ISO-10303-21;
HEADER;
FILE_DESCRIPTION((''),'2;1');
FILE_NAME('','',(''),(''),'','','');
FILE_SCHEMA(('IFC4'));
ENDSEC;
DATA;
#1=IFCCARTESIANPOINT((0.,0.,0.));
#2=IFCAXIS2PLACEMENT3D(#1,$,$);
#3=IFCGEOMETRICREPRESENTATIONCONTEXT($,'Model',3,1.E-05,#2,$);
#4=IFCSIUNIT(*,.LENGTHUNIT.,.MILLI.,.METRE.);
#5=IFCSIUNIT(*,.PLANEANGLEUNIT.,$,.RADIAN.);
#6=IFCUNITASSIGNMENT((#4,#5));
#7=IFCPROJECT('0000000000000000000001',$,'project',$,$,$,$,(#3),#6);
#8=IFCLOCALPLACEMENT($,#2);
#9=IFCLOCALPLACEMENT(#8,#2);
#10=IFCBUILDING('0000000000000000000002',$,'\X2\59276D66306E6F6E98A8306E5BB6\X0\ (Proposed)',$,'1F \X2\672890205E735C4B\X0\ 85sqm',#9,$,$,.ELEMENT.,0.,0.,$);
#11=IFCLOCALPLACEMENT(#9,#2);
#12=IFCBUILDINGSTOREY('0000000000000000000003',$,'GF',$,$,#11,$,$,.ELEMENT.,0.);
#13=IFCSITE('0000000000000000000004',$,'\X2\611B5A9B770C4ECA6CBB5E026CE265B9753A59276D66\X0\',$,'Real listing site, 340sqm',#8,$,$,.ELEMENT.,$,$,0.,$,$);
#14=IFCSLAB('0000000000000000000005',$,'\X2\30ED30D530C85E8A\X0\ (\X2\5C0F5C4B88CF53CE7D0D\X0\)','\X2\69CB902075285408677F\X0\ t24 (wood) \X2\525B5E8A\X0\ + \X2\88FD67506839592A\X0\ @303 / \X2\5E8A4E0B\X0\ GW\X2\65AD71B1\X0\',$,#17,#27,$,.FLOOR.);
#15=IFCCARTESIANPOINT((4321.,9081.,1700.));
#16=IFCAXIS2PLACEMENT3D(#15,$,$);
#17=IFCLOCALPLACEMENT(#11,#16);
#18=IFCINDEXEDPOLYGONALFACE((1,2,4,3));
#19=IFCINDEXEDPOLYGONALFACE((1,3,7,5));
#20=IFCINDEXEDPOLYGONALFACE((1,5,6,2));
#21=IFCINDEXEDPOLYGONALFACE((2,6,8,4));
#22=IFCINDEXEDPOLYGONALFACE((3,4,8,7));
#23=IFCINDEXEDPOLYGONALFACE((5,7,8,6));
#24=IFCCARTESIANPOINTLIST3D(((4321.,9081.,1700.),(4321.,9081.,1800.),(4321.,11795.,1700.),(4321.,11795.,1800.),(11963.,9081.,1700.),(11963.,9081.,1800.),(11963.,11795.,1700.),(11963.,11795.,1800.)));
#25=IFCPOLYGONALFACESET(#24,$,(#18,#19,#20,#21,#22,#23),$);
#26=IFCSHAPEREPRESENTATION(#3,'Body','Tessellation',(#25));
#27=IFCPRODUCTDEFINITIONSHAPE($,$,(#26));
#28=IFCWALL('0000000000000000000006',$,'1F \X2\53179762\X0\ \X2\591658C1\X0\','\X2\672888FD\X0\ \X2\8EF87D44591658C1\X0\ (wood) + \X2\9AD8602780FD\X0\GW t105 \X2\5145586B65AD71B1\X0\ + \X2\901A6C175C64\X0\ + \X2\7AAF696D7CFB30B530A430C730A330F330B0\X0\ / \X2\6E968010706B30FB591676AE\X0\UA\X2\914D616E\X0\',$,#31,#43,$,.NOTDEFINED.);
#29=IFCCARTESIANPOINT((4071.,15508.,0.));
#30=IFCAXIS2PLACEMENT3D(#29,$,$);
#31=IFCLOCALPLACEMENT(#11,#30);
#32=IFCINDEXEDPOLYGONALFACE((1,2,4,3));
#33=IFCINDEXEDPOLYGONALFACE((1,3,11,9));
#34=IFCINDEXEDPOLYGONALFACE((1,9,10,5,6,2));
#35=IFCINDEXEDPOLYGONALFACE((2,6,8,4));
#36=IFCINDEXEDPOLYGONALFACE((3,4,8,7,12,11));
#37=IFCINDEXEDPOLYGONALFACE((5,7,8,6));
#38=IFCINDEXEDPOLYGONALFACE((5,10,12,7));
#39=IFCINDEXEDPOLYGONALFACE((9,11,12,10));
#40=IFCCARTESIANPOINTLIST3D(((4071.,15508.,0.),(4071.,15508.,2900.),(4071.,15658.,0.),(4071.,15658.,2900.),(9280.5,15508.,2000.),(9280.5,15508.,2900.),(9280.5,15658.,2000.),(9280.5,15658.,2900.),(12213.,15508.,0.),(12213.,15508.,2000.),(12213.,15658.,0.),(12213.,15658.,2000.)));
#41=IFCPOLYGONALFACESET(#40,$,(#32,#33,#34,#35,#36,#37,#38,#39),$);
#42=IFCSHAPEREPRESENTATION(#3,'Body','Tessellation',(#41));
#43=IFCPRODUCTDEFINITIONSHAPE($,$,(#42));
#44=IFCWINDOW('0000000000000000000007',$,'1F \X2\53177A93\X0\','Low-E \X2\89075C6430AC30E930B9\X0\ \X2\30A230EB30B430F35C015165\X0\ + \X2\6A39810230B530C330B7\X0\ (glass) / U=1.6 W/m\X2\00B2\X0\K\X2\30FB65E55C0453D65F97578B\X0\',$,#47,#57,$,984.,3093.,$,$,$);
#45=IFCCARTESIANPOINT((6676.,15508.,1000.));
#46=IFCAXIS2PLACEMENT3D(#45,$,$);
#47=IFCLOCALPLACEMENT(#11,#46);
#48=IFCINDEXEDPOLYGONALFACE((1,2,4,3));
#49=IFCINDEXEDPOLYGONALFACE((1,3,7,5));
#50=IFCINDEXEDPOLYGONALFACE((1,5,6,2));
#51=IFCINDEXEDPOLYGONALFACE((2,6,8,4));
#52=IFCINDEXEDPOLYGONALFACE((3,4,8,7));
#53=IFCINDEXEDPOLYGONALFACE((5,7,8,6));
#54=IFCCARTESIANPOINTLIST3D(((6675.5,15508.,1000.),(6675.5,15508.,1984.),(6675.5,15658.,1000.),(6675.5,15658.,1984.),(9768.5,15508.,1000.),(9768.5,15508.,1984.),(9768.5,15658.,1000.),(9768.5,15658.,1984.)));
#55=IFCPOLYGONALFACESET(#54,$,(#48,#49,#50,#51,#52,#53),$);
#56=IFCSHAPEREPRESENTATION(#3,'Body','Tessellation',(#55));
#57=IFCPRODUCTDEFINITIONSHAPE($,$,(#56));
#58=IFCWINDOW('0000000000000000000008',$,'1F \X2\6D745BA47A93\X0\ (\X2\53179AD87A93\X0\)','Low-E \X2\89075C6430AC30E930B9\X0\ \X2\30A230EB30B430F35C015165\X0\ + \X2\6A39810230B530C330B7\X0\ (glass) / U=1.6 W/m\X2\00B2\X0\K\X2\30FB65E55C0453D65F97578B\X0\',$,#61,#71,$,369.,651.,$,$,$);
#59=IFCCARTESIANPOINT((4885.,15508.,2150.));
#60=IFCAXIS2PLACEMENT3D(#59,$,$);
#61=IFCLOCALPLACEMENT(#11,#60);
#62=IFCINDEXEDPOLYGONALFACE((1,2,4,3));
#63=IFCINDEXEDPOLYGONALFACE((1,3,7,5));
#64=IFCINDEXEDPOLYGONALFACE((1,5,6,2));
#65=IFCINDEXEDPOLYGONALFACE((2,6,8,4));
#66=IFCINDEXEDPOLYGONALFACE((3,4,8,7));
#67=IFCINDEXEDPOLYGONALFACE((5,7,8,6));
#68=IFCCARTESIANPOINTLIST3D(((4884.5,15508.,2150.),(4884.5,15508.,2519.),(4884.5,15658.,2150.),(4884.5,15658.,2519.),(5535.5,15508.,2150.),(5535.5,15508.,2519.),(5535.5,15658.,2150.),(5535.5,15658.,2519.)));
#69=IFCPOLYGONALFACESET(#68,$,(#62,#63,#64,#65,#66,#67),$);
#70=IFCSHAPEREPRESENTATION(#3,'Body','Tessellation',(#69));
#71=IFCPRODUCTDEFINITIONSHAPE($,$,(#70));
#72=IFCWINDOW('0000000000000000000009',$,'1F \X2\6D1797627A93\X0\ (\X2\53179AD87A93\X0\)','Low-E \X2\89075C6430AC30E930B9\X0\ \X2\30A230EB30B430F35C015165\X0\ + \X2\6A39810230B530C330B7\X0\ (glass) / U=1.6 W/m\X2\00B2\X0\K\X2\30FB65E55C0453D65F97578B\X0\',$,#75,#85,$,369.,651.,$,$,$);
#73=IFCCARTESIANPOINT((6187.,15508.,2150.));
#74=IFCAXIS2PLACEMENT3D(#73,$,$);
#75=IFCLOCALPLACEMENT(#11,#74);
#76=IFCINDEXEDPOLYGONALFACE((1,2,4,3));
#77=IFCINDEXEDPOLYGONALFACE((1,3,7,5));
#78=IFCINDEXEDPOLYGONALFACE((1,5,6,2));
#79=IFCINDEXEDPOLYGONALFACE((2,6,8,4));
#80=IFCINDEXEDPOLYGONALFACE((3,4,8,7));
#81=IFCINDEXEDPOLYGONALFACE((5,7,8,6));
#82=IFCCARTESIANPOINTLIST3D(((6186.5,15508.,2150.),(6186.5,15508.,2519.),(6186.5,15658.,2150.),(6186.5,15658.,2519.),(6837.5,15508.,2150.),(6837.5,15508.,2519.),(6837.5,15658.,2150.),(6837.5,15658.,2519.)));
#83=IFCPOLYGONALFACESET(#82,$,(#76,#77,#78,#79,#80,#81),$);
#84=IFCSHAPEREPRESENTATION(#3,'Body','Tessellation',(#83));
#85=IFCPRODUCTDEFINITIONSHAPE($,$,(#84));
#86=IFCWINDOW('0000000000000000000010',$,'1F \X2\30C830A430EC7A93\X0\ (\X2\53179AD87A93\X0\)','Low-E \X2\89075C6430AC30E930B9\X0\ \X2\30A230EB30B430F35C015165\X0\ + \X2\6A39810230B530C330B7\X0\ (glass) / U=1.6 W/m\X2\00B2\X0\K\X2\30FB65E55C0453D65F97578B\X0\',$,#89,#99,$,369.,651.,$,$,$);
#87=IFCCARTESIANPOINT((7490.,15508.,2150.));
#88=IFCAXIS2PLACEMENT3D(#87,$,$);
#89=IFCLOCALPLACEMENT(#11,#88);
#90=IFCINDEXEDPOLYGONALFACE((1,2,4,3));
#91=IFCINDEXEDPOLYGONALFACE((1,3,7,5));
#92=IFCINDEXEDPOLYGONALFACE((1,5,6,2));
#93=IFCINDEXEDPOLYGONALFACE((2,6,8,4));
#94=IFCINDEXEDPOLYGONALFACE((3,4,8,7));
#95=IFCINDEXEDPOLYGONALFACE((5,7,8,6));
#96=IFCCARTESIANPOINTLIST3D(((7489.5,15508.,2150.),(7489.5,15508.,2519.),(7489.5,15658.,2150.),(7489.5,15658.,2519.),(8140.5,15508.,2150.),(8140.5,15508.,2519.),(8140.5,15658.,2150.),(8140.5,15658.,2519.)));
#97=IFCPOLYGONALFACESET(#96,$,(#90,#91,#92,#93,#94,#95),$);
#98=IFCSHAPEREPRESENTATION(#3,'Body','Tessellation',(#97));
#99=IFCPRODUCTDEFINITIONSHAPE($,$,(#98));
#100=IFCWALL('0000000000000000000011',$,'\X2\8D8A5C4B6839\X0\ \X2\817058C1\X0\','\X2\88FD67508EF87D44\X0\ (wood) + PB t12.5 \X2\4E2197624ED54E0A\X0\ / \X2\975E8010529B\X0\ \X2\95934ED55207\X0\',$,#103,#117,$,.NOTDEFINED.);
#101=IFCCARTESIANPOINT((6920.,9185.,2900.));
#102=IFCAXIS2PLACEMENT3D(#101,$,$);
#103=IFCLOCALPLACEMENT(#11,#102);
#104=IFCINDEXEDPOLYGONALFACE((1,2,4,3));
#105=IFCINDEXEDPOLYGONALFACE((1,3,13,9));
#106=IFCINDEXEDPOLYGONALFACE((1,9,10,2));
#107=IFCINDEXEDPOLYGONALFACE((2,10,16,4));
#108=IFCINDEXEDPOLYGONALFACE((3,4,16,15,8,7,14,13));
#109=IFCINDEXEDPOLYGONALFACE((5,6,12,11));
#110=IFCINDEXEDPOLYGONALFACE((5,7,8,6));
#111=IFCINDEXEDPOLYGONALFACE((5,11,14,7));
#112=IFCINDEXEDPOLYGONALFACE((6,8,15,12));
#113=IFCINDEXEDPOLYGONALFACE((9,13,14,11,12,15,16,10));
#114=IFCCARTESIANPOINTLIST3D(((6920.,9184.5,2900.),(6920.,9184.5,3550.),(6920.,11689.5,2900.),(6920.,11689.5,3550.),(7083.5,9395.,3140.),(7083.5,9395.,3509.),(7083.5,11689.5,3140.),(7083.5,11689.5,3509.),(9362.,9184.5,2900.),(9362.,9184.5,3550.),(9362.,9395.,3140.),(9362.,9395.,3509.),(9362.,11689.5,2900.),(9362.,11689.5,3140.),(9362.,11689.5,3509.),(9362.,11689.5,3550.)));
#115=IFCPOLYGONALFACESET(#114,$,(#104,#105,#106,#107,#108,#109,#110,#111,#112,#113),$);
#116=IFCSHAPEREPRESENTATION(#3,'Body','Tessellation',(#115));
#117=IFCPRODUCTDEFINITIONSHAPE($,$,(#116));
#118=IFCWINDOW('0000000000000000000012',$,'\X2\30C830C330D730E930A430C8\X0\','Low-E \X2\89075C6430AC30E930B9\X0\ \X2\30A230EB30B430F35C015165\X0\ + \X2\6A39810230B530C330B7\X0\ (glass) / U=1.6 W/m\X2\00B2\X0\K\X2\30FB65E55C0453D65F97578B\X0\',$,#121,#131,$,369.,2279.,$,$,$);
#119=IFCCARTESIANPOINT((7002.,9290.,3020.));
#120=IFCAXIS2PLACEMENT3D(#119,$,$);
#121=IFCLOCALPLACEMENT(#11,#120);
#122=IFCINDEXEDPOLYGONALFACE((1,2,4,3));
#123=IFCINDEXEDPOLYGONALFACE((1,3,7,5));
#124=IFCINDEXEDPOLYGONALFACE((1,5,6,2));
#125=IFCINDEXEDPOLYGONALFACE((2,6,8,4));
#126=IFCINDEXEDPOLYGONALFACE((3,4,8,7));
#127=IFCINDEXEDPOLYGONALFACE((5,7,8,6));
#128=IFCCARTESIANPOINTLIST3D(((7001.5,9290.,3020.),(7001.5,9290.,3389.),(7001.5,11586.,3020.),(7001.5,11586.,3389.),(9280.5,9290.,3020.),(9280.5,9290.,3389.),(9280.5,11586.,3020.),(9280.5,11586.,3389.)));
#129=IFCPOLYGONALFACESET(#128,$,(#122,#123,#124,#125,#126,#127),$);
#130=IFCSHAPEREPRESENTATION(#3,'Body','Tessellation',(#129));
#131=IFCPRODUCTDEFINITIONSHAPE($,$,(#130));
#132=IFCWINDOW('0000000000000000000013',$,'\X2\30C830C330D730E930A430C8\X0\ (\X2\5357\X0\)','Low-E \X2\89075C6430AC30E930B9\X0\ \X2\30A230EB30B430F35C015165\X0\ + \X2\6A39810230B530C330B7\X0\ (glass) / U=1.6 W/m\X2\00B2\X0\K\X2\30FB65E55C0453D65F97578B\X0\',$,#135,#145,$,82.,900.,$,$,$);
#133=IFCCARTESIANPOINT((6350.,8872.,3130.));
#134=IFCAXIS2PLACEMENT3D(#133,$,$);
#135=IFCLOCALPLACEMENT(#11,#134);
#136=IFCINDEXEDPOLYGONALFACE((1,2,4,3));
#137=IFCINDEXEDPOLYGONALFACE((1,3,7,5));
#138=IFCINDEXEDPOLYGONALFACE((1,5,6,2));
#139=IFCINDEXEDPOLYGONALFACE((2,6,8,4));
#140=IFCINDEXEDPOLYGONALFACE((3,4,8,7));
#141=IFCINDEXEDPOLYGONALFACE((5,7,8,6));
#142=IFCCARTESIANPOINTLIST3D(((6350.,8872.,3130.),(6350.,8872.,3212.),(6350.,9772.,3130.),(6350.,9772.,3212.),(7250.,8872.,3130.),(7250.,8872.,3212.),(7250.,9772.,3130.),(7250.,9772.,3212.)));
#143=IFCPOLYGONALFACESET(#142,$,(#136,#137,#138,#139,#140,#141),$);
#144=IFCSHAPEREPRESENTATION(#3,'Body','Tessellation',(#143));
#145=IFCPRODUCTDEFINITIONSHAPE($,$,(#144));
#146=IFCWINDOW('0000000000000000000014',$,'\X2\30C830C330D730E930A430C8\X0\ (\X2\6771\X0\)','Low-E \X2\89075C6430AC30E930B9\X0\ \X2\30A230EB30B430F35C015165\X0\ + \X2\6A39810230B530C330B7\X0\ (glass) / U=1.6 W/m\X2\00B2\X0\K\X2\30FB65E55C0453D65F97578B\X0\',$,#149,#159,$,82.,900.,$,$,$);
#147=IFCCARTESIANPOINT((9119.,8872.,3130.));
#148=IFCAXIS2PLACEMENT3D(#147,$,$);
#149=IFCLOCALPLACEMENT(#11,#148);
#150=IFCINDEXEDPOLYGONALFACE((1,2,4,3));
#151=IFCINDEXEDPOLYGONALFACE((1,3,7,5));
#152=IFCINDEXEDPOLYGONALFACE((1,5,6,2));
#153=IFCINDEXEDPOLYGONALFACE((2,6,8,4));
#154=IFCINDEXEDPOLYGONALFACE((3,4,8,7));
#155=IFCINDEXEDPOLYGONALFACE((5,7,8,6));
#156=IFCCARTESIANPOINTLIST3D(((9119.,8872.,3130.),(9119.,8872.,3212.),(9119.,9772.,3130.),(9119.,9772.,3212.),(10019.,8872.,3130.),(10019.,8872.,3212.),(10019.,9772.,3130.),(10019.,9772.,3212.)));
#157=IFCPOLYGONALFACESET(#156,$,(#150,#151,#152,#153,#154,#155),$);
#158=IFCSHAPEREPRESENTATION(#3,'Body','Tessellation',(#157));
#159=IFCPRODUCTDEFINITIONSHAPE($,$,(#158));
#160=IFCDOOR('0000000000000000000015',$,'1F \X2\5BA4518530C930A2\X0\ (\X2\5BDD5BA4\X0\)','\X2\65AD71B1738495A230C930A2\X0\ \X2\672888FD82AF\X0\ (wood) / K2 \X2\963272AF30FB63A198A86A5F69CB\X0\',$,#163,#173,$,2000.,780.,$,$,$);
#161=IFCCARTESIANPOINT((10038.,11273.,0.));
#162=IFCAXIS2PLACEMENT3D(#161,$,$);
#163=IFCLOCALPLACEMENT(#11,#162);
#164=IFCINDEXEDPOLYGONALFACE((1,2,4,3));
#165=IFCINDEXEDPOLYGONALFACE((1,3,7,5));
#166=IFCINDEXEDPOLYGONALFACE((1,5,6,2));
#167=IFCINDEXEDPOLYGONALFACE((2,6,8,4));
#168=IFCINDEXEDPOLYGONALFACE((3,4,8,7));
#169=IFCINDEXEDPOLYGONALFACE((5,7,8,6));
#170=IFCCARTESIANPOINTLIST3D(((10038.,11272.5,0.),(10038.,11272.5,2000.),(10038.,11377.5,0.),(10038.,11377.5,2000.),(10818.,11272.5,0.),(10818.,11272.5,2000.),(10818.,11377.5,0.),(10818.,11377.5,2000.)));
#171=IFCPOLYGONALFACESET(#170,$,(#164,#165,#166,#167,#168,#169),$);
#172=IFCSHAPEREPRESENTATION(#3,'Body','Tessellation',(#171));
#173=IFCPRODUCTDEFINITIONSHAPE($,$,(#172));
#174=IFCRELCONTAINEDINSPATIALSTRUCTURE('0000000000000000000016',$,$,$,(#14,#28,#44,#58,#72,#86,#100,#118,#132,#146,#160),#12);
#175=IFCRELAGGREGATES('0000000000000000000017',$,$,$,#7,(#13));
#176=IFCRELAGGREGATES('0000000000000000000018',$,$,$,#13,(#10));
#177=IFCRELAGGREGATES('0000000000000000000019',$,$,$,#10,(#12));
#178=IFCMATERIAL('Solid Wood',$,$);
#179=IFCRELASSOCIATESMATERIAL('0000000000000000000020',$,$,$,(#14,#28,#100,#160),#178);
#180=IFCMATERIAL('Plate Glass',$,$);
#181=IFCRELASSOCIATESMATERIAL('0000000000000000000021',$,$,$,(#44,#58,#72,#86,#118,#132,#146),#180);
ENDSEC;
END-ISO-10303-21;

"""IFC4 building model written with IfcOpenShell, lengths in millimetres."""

from ifc_helpers import new_model, si_unit, frame, frame_2d, origin, place, context, project, spatial, rectangle, extrude, material, element, fill, save


model = new_model("IFC4")

# Units and contexts
model_context = context("Model", 3, precision=1e-05, world=origin())
ifc_project = project(units=[si_unit("LENGTHUNIT", "METRE", prefix="MILLI"), si_unit("PLANEANGLEUNIT", "RADIAN")], contexts=[model_context])

# Site, building, storey
site_placement = place(None, origin())
site = spatial("IfcSite", under=ifc_project, at=site_placement, Name="愛媛県今治市波方町大浦", ObjectType="Real listing site, 340sqm", CompositionType="ELEMENT", RefElevation=0.0)
building_placement = place(site_placement, origin())
building = spatial("IfcBuilding", under=site, at=building_placement, Name="大浦の潮風の家 (Proposed)", ObjectType="1F 木造平屋 85sqm", CompositionType="ELEMENT", ElevationOfRefHeight=0.0, ElevationOfTerrain=0.0)
storey_placement = place(building_placement, origin())
storey = spatial("IfcBuildingStorey", under=building, at=storey_placement, Name="GF", CompositionType="ELEMENT", Elevation=0.0)

# Slab
ifc_material_1 = material(Name="Solid Wood")
slab_placement = place(storey_placement, frame((4321.0, 9081.0, 1700.0)))
element("IfcSlab", 1, at=slab_placement, inside=storey, material=ifc_material_1, Name="ロフト床 (小屋裏収納)", Description="構造用合板 t24 (wood) 剛床 + 製材根太 @303 / 床下 GW断熱", PredefinedType="FLOOR", context=model_context, shape_type="SweptSolid", body=[
    extrude(rectangle(XDim=7642.0, YDim=2714.0, at=frame_2d((3821.0, 1357.0))), frame((4321.0, 9081.0, 1700.0)), (0.0, 0.0, 1.0), 100.0),
])

# Wall, openings, windows
wall_1_placement = place(storey_placement, frame((4071.0, 15508.0, 0.0)))
wall_1 = element("IfcWall", 2, at=wall_1_placement, inside=storey, material=ifc_material_1, Name="1F 北面 外壁", Description="木製 軸組外壁 (wood) + 高性能GW t105 充填断熱 + 通気層 + 窯業系サイディング / 準耐火・外皮UA配慮", PredefinedType="NOTDEFINED", context=model_context, shape_type="SweptSolid", body=[
    extrude(rectangle(XDim=8142.0, YDim=150.0, at=frame_2d((4071.0, 75.0))), frame((4071.0, 15508.0, 0.0)), (0.0, 0.0, 1.0), 2900.0),
])
opening_1_placement = place(storey_placement, frame((6676.0, 15508.0, 1000.0)))
opening_1 = element("IfcOpeningElement", 3, at=opening_1_placement, cuts=wall_1, PredefinedType="NOTDEFINED", context=model_context, shape_type="SweptSolid", body=[
    extrude(rectangle(XDim=3093.0, YDim=150.0, at=frame_2d((1546.0, 75.0))), frame((6676.0, 15508.0, 1000.0)), (0.0, 0.0, 1.0), 984.0),
])
opening_2_placement = place(storey_placement, frame((4885.0, 15508.0, 2150.0)))
opening_2 = element("IfcOpeningElement", 4, at=opening_2_placement, cuts=wall_1, PredefinedType="NOTDEFINED", context=model_context, shape_type="SweptSolid", body=[
    extrude(rectangle(XDim=651.0, YDim=150.0, at=frame_2d((325.0, 75.0))), frame((4885.0, 15508.0, 2150.0)), (0.0, 0.0, 1.0), 369.0),
])
opening_3_placement = place(storey_placement, frame((6187.0, 15508.0, 2150.0)))
opening_3 = element("IfcOpeningElement", 5, at=opening_3_placement, cuts=wall_1, PredefinedType="NOTDEFINED", context=model_context, shape_type="SweptSolid", body=[
    extrude(rectangle(XDim=651.0, YDim=150.0, at=frame_2d((325.0, 75.0))), frame((6187.0, 15508.0, 2150.0)), (0.0, 0.0, 1.0), 369.0),
])
opening_4_placement = place(storey_placement, frame((7490.0, 15508.0, 2150.0)))
opening_4 = element("IfcOpeningElement", 6, at=opening_4_placement, cuts=wall_1, PredefinedType="NOTDEFINED", context=model_context, shape_type="SweptSolid", body=[
    extrude(rectangle(XDim=651.0, YDim=150.0, at=frame_2d((325.0, 75.0))), frame((7490.0, 15508.0, 2150.0)), (0.0, 0.0, 1.0), 369.0),
])
ifc_material_2 = material(Name="Plate Glass")
window_1_placement = place(storey_placement, frame((6676.0, 15508.0, 1000.0)))
window_1 = element("IfcWindow", 7, at=window_1_placement, inside=storey, material=ifc_material_2, Name="1F 北窓", Description="Low-E 複層ガラス アルゴン封入 + 樹脂サッシ (glass) / U=1.6 W/m²K・日射取得型", OverallHeight=984.0, OverallWidth=3093.0, context=model_context, shape_type="SweptSolid", body=[
    extrude(rectangle(XDim=3093.0, YDim=150.0, at=frame_2d((1546.0, 75.0))), frame((6676.0, 15508.0, 1000.0)), (0.0, 0.0, 1.0), 984.0),
])
fill(opening_1, window_1)
window_2_placement = place(storey_placement, frame((4885.0, 15508.0, 2150.0)))
window_2 = element("IfcWindow", 8, at=window_2_placement, inside=storey, material=ifc_material_2, Name="1F 浴室窓 (北高窓)", Description="Low-E 複層ガラス アルゴン封入 + 樹脂サッシ (glass) / U=1.6 W/m²K・日射取得型", OverallHeight=369.0, OverallWidth=651.0, context=model_context, shape_type="SweptSolid", body=[
    extrude(rectangle(XDim=651.0, YDim=150.0, at=frame_2d((325.0, 75.0))), frame((4885.0, 15508.0, 2150.0)), (0.0, 0.0, 1.0), 369.0),
])
fill(opening_2, window_2)
window_3_placement = place(storey_placement, frame((6187.0, 15508.0, 2150.0)))
window_3 = element("IfcWindow", 9, at=window_3_placement, inside=storey, material=ifc_material_2, Name="1F 洗面窓 (北高窓)", Description="Low-E 複層ガラス アルゴン封入 + 樹脂サッシ (glass) / U=1.6 W/m²K・日射取得型", OverallHeight=369.0, OverallWidth=651.0, context=model_context, shape_type="SweptSolid", body=[
    extrude(rectangle(XDim=651.0, YDim=150.0, at=frame_2d((325.0, 75.0))), frame((6187.0, 15508.0, 2150.0)), (0.0, 0.0, 1.0), 369.0),
])
fill(opening_3, window_3)
window_4_placement = place(storey_placement, frame((7490.0, 15508.0, 2150.0)))
window_4 = element("IfcWindow", 10, at=window_4_placement, inside=storey, material=ifc_material_2, Name="1F トイレ窓 (北高窓)", Description="Low-E 複層ガラス アルゴン封入 + 樹脂サッシ (glass) / U=1.6 W/m²K・日射取得型", OverallHeight=369.0, OverallWidth=651.0, context=model_context, shape_type="SweptSolid", body=[
    extrude(rectangle(XDim=651.0, YDim=150.0, at=frame_2d((325.0, 75.0))), frame((7490.0, 15508.0, 2150.0)), (0.0, 0.0, 1.0), 369.0),
])
fill(opening_4, window_4)

# Wall, openings, windows
wall_2_placement = place(storey_placement, frame((6920.0, 9185.0, 2900.0)))
wall_2 = element("IfcWall", 11, at=wall_2_placement, inside=storey, material=ifc_material_1, Name="越屋根 腰壁", Description="製材軸組 (wood) + PB t12.5 両面仕上 / 非耐力 間仕切", PredefinedType="NOTDEFINED", context=model_context, shape_type="SweptSolid", body=[
    extrude(rectangle(XDim=2442.0, YDim=2505.0, at=frame_2d((1221.0, 1252.0))), frame((6920.0, 9185.0, 2900.0)), (0.0, 0.0, 1.0), 650.0),
])
opening_5_placement = place(storey_placement, frame((7002.0, 9290.0, 3020.0)))
opening_5 = element("IfcOpeningElement", 12, at=opening_5_placement, cuts=wall_2, PredefinedType="NOTDEFINED", context=model_context, shape_type="SweptSolid", body=[
    extrude(rectangle(XDim=2279.0, YDim=2296.0, at=frame_2d((1139.0, 1148.0))), frame((7002.0, 9290.0, 3020.0)), (0.0, 0.0, 1.0), 369.0),
])
opening_6_placement = place(storey_placement, frame((6350.0, 8872.0, 3130.0)))
opening_6 = element("IfcOpeningElement", 13, at=opening_6_placement, cuts=wall_2, PredefinedType="NOTDEFINED", context=model_context, shape_type="SweptSolid", body=[
    extrude(rectangle(XDim=900.0, YDim=900.0, at=frame_2d((450.0, 450.0))), frame((6350.0, 8872.0, 3130.0)), (0.0, 0.0, 1.0), 82.0),
])
opening_7_placement = place(storey_placement, frame((9119.0, 8872.0, 3130.0)))
opening_7 = element("IfcOpeningElement", 14, at=opening_7_placement, cuts=wall_2, PredefinedType="NOTDEFINED", context=model_context, shape_type="SweptSolid", body=[
    extrude(rectangle(XDim=900.0, YDim=900.0, at=frame_2d((450.0, 450.0))), frame((9119.0, 8872.0, 3130.0)), (0.0, 0.0, 1.0), 82.0),
])
window_5_placement = place(storey_placement, frame((7002.0, 9290.0, 3020.0)))
window_5 = element("IfcWindow", 15, at=window_5_placement, inside=storey, material=ifc_material_2, Name="トップライト", Description="Low-E 複層ガラス アルゴン封入 + 樹脂サッシ (glass) / U=1.6 W/m²K・日射取得型", OverallHeight=369.0, OverallWidth=2279.0, context=model_context, shape_type="SweptSolid", body=[
    extrude(rectangle(XDim=2279.0, YDim=2296.0, at=frame_2d((1139.0, 1148.0))), frame((7002.0, 9290.0, 3020.0)), (0.0, 0.0, 1.0), 369.0),
])
fill(opening_5, window_5)
window_6_placement = place(storey_placement, frame((6350.0, 8872.0, 3130.0)))
window_6 = element("IfcWindow", 16, at=window_6_placement, inside=storey, material=ifc_material_2, Name="トップライト (南)", Description="Low-E 複層ガラス アルゴン封入 + 樹脂サッシ (glass) / U=1.6 W/m²K・日射取得型", OverallHeight=82.0, OverallWidth=900.0, context=model_context, shape_type="SweptSolid", body=[
    extrude(rectangle(XDim=900.0, YDim=900.0, at=frame_2d((450.0, 450.0))), frame((6350.0, 8872.0, 3130.0)), (0.0, 0.0, 1.0), 82.0),
])
fill(opening_6, window_6)
window_7_placement = place(storey_placement, frame((9119.0, 8872.0, 3130.0)))
window_7 = element("IfcWindow", 17, at=window_7_placement, inside=storey, material=ifc_material_2, Name="トップライト (東)", Description="Low-E 複層ガラス アルゴン封入 + 樹脂サッシ (glass) / U=1.6 W/m²K・日射取得型", OverallHeight=82.0, OverallWidth=900.0, context=model_context, shape_type="SweptSolid", body=[
    extrude(rectangle(XDim=900.0, YDim=900.0, at=frame_2d((450.0, 450.0))), frame((9119.0, 8872.0, 3130.0)), (0.0, 0.0, 1.0), 82.0),
])
fill(opening_7, window_7)

# Door
door_1_placement = place(storey_placement, frame((10038.0, 11273.0, 0.0)))
element("IfcDoor", 18, at=door_1_placement, inside=storey, material=ifc_material_1, Name="1F 室内ドア (寝室)", Description="断熱玄関ドア 木製芯 (wood) / K2 防犯・採風機構", OverallHeight=2000.0, OverallWidth=780.0, context=model_context, shape_type="SweptSolid", body=[
    extrude(rectangle(XDim=780.0, YDim=105.0, at=frame_2d((390.0, 52.0))), frame((10038.0, 11273.0, 0.0)), (0.0, 0.0, 1.0), 2000.0),
])

save(model, "model.ifc")
